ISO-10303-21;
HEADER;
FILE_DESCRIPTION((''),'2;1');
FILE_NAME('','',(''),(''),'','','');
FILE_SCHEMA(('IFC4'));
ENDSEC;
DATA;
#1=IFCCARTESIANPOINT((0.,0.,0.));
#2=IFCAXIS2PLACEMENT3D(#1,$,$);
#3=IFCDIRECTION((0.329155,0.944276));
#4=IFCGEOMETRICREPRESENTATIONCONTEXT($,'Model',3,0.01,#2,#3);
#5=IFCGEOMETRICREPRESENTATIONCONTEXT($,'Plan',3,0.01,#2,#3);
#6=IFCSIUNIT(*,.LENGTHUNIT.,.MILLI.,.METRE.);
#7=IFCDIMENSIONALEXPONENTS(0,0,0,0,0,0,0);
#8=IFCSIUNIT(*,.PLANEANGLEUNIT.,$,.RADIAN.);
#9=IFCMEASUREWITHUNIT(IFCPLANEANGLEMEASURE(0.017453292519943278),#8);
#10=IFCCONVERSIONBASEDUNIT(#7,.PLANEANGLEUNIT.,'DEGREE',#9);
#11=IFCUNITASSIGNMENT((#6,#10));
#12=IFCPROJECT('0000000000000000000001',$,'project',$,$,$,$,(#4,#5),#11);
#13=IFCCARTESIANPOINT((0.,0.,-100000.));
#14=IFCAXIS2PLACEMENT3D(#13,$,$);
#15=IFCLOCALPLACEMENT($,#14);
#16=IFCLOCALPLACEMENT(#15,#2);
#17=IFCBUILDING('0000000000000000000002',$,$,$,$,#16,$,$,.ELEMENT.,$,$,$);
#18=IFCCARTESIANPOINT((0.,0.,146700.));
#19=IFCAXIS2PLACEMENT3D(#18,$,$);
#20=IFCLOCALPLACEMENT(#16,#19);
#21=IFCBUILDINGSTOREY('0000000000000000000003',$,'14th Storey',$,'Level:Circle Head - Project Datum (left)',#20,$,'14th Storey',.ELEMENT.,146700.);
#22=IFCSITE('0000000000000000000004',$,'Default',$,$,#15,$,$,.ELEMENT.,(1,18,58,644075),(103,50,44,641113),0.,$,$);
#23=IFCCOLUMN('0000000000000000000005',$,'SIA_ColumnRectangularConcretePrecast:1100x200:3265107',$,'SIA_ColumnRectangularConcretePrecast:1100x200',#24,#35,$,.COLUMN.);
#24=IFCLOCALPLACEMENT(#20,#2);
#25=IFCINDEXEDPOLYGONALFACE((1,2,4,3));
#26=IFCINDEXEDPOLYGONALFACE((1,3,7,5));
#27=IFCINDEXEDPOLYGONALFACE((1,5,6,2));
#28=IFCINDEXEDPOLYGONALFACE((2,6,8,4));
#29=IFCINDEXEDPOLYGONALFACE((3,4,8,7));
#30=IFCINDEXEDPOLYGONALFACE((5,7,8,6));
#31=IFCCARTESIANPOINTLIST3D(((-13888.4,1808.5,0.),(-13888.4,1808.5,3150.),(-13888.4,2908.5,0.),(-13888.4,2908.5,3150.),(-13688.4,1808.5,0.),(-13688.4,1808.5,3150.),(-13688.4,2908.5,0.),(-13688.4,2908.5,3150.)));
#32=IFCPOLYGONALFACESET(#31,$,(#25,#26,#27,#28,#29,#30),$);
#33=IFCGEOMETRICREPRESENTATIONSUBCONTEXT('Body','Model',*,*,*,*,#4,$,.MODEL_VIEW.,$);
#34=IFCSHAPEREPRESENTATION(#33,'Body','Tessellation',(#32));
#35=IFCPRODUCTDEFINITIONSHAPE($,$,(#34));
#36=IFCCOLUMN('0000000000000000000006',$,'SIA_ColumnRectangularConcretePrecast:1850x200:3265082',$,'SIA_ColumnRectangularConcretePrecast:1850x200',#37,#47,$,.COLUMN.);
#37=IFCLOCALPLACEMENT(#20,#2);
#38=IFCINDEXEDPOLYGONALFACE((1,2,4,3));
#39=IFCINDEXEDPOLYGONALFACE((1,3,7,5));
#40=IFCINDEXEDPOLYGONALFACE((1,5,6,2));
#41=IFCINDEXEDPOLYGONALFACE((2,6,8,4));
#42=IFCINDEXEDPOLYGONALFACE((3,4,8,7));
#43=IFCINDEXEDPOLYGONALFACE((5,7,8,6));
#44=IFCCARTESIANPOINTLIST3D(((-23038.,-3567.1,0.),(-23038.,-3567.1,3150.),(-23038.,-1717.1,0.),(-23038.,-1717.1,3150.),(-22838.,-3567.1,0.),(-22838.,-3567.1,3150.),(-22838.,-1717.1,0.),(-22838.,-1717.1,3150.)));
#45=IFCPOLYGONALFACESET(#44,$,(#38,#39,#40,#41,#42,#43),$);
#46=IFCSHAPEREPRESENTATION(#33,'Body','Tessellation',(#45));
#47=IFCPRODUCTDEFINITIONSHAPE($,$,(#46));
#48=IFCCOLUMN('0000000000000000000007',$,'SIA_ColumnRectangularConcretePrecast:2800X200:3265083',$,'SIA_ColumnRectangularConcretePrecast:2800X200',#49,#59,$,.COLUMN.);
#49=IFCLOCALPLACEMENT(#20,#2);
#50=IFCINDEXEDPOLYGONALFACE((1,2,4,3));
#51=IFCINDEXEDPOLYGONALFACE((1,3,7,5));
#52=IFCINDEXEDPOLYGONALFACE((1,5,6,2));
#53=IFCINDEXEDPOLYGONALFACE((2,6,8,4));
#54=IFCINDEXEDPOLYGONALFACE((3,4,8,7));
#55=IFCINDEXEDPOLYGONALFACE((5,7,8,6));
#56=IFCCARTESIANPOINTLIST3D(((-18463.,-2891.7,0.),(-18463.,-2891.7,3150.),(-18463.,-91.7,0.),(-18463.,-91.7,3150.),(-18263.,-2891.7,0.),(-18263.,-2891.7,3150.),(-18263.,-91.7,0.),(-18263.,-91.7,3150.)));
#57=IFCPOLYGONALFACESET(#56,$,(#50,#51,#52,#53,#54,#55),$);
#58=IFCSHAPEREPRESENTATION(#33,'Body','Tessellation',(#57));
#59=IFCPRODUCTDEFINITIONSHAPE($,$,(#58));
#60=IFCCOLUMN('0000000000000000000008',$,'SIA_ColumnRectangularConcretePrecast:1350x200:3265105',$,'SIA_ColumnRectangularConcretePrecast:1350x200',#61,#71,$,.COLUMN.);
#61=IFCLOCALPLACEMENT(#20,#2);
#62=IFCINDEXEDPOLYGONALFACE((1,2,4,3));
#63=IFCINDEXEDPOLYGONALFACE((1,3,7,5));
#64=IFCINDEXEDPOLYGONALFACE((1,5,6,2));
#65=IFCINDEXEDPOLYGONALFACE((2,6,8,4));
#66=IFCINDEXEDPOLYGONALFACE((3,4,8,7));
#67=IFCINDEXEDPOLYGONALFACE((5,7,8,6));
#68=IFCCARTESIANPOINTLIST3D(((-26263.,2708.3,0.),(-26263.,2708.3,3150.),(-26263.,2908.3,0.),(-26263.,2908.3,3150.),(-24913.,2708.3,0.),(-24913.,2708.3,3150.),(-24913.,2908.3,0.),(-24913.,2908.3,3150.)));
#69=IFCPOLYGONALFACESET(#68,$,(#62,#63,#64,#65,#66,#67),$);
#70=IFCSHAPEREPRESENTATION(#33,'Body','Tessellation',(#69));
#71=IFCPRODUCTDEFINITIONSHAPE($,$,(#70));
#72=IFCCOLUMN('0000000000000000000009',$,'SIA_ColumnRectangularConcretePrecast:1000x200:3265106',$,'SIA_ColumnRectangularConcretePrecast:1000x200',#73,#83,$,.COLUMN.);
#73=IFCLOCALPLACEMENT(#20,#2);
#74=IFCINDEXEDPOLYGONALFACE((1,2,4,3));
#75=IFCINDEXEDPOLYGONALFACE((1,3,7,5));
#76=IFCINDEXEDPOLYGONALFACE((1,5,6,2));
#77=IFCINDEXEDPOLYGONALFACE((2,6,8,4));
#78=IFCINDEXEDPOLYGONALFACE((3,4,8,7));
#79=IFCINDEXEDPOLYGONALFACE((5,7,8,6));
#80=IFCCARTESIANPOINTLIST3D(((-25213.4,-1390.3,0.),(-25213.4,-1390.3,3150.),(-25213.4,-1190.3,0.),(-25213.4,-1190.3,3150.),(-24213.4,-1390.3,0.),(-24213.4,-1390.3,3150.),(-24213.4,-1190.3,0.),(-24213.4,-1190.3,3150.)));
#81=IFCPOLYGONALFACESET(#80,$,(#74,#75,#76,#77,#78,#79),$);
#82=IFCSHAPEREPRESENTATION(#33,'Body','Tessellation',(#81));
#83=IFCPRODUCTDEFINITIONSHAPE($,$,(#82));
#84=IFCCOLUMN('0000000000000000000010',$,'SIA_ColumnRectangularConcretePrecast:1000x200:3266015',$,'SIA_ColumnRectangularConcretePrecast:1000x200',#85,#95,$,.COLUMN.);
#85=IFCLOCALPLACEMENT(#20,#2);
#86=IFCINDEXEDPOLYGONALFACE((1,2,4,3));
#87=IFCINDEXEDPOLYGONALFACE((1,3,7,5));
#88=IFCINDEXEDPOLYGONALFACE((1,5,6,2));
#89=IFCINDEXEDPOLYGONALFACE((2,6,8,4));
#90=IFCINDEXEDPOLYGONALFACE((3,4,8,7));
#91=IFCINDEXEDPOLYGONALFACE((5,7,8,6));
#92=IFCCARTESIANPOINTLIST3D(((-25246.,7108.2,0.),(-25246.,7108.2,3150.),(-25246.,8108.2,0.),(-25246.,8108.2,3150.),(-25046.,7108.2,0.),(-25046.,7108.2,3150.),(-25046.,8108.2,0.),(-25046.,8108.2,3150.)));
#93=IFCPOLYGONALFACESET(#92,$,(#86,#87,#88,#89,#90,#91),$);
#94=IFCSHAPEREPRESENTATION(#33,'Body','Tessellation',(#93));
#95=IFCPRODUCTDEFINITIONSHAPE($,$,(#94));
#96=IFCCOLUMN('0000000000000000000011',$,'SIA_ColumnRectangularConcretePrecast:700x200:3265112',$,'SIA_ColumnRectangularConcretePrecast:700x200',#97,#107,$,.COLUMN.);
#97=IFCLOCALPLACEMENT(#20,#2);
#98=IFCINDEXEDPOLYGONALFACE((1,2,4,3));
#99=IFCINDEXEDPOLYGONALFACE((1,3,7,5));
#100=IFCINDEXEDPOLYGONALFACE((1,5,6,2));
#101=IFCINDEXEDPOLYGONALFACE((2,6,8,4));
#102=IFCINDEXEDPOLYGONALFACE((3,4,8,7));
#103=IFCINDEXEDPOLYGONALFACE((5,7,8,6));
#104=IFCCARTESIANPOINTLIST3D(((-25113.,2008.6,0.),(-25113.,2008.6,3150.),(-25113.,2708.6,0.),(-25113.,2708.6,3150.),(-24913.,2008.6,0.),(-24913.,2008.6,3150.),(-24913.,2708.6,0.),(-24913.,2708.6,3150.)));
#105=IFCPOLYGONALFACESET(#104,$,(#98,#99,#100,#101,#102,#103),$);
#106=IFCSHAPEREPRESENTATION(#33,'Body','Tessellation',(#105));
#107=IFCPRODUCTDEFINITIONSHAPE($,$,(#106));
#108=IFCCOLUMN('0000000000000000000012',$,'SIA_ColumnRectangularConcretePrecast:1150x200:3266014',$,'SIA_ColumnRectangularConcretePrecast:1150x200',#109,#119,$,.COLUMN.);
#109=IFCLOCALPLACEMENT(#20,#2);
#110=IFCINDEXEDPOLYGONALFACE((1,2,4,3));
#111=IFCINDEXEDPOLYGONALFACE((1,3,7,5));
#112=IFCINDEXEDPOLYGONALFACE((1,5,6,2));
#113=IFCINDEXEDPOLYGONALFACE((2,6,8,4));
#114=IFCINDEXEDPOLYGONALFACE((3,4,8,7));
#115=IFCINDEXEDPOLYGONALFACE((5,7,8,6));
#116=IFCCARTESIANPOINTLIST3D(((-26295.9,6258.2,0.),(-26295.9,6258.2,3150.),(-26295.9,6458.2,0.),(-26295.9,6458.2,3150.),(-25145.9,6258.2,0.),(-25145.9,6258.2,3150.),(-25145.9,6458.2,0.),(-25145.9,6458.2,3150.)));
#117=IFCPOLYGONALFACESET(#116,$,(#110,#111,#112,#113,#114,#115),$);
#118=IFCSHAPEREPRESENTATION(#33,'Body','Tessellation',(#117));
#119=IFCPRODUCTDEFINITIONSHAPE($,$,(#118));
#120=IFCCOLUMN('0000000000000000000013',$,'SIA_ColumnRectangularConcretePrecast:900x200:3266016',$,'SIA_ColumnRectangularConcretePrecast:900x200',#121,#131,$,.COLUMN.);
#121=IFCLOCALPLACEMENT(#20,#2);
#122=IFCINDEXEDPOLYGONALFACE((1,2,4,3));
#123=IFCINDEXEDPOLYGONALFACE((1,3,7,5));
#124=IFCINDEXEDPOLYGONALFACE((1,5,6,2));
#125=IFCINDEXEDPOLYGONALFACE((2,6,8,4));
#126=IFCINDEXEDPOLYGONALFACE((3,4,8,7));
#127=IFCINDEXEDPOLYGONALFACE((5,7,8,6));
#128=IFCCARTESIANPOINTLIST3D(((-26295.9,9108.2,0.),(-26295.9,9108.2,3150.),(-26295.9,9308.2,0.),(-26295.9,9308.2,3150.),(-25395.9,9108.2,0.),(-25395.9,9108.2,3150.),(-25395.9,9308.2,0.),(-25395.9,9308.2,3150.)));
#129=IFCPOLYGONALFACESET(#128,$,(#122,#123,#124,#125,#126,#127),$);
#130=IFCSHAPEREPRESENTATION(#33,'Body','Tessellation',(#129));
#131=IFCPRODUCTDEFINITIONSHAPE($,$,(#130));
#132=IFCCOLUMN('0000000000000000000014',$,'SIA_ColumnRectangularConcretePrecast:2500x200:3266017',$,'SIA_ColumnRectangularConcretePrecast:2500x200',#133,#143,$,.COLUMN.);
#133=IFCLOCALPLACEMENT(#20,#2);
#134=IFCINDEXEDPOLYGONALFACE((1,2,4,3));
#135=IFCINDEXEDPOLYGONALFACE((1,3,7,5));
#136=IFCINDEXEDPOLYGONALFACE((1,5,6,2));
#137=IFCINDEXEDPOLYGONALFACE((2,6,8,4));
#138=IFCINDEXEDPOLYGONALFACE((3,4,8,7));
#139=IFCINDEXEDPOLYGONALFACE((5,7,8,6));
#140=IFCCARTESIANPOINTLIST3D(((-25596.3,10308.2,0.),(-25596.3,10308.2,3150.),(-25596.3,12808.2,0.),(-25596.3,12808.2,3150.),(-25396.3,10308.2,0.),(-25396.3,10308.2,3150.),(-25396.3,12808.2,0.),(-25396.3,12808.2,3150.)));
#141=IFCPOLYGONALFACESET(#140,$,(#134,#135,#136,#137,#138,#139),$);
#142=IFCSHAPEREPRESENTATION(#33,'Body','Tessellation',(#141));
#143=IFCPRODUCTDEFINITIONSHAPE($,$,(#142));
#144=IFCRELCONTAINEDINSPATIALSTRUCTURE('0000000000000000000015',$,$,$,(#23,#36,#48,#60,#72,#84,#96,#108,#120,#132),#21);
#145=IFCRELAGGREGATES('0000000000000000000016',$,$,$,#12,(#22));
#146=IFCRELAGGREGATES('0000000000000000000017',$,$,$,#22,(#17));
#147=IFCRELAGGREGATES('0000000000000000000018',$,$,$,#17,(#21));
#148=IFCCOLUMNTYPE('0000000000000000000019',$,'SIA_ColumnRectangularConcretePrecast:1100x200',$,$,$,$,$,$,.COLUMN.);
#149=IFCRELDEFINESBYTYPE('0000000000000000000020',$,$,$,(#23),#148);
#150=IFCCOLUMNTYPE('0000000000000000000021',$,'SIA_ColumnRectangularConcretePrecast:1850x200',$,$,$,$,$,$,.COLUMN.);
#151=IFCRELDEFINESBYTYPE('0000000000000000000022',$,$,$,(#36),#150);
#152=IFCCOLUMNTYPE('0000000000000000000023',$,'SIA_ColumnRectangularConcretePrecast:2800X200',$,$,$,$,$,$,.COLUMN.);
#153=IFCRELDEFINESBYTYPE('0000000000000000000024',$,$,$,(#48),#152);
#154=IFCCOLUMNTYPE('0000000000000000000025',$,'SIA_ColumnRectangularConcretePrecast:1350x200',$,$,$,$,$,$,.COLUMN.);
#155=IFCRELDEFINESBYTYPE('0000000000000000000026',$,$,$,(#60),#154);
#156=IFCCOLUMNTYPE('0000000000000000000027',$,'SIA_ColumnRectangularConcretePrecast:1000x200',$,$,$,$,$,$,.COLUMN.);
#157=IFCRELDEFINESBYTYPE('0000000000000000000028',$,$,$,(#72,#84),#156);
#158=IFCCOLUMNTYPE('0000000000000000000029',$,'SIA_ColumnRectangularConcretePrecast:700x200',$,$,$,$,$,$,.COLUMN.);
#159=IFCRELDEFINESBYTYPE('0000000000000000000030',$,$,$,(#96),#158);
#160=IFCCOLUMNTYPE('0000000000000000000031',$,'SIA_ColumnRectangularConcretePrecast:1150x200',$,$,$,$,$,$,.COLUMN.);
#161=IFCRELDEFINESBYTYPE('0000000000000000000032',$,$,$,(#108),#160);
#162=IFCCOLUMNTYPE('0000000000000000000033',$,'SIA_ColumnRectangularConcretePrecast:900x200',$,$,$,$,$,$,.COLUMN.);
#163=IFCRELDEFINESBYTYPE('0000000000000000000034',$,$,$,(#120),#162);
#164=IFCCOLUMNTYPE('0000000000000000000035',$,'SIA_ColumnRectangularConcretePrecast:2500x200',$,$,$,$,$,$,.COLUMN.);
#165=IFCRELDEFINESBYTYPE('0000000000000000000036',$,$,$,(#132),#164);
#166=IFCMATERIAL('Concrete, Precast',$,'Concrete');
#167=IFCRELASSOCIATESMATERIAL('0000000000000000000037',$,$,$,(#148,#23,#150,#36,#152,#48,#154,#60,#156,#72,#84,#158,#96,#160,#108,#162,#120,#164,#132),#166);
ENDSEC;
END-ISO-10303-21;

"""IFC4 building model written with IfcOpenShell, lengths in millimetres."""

from ifc_helpers import new_model, entity, si_unit, converted_unit, direction, frame, origin, place, context, subcontext, project, spatial, indexed_curve, outline, extrude, source, transform, mapped, material, type_object, type_shapes, element, save


model = new_model("IFC4")

# Units and contexts
model_context = context("Model", 3, precision=0.01, world=origin(), true_north=direction((0.329155, 0.944276)))
plan_context = context("Plan", 3, precision=0.01, world=origin(), true_north=direction((0.329155, 0.944276)))
body_context = subcontext(model_context, "Body", "Model", "MODEL_VIEW")
ifc_project = project(units=[si_unit("LENGTHUNIT", "METRE", prefix="MILLI"), converted_unit("PLANEANGLEUNIT", "DEGREE", entity("IfcPlaneAngleMeasure", 0.017453292519943278), si_unit("PLANEANGLEUNIT", "RADIAN"), dimensions=[0, 0, 0, 0, 0, 0, 0])], contexts=[model_context, plan_context])

# Site, building, storey
site_placement = place(None, frame((0.0, 0.0, -100000.0)))
site = spatial("IfcSite", under=ifc_project, at=site_placement, Name="Default", CompositionType="ELEMENT", RefLatitude=(1, 18, 58, 644075), RefLongitude=(103, 50, 44, 641113), RefElevation=0.0)
building_placement = place(site_placement, origin())
building = spatial("IfcBuilding", under=site, at=building_placement, CompositionType="ELEMENT")
storey_placement = place(building_placement, frame((0.0, 0.0, 146700.0)))
storey = spatial("IfcBuildingStorey", under=building, at=storey_placement, Name="14th Storey", ObjectType="Level:Circle Head - Project Datum (left)", LongName="14th Storey", CompositionType="ELEMENT", Elevation=146700.0)

# Columns
ifc_material_1 = material(Name="Concrete, Precast", Category="Concrete")
column_type_1 = type_object("IfcColumnType", Name="SIA_ColumnRectangularConcretePrecast:1100x200", PredefinedType="COLUMN", material=ifc_material_1)
shared_shape_1 = source(origin(), body_context, "Body", "SweptSolid", [
    extrude(outline(indexed_curve([(-100.0, -550.0), (100.0, -550.0), (100.0, 550.0), (-100.0, 550.0), (-100.0, -550.0)], self_intersect=False)), frame((0.0, 0.0, 146700.0), z_axis=(0.0, 0.0, 1.0), x_axis=(-1.0, 0.0, 0.0)), (0.0, 0.0, 1.0), 3150.0),
])
type_shapes(column_type_1, [shared_shape_1])
for number, where, name in (
    (1, (-13788.4, 2358.5, -146700.0), "SIA_ColumnRectangularConcretePrecast:1100x200:3265107"),
):
    element("IfcColumn", number, at=place(storey_placement, frame(where)), inside=storey, type_object=column_type_1, material=ifc_material_1, Name=name, ObjectType="SIA_ColumnRectangularConcretePrecast:1100x200", PredefinedType="COLUMN", context=body_context, shape_type="MappedRepresentation", body=[
        mapped(shared_shape_1, transform((0.0, 0.0, 0.0), scale=1.0)),
    ])
column_type_2 = type_object("IfcColumnType", Name="SIA_ColumnRectangularConcretePrecast:1850x200", PredefinedType="COLUMN", material=ifc_material_1)
shared_shape_2 = source(origin(), body_context, "Body", "SweptSolid", [
    extrude(outline(indexed_curve([(-100.0, -925.0), (100.0, -925.0), (100.0, 925.0), (-100.0, 925.0), (-100.0, -925.0)], self_intersect=False)), frame((0.0, 0.0, 146700.0), z_axis=(0.0, 0.0, 1.0), x_axis=(-1.0, 0.0, 0.0)), (0.0, 0.0, 1.0), 3150.0),
])
type_shapes(column_type_2, [shared_shape_2])
column_1_placement = place(storey_placement, frame((-22938.0, -2642.1, -146700.0)))
element("IfcColumn", 2, at=column_1_placement, inside=storey, type_object=column_type_2, material=ifc_material_1, Name="SIA_ColumnRectangularConcretePrecast:1850x200:3265082", ObjectType="SIA_ColumnRectangularConcretePrecast:1850x200", PredefinedType="COLUMN", context=body_context, shape_type="MappedRepresentation", body=[
    mapped(shared_shape_2, transform((0.0, 0.0, 0.0), scale=1.0)),
])
column_type_3 = type_object("IfcColumnType", Name="SIA_ColumnRectangularConcretePrecast:2800X200", PredefinedType="COLUMN", material=ifc_material_1)
shared_shape_3 = source(origin(), body_context, "Body", "SweptSolid", [
    extrude(outline(indexed_curve([(-100.0, -1400.0), (100.0, -1400.0), (100.0, 1400.0), (-100.0, 1400.0), (-100.0, -1400.0)], self_intersect=False)), frame((0.0, 0.0, 146700.0), z_axis=(0.0, 0.0, 1.0), x_axis=(-1.0, 0.0, 0.0)), (0.0, 0.0, 1.0), 3150.0),
])
type_shapes(column_type_3, [shared_shape_3])
column_2_placement = place(storey_placement, frame((-18363.0, -1491.7, -146700.0)))
element("IfcColumn", 3, at=column_2_placement, inside=storey, type_object=column_type_3, material=ifc_material_1, Name="SIA_ColumnRectangularConcretePrecast:2800X200:3265083", ObjectType="SIA_ColumnRectangularConcretePrecast:2800X200", PredefinedType="COLUMN", context=body_context, shape_type="MappedRepresentation", body=[
    mapped(shared_shape_3, transform((0.0, 0.0, 0.0), scale=1.0)),
])
column_type_4 = type_object("IfcColumnType", Name="SIA_ColumnRectangularConcretePrecast:1350x200", PredefinedType="COLUMN", material=ifc_material_1)
shared_shape_4 = source(origin(), body_context, "Body", "SweptSolid", [
    extrude(outline(indexed_curve([(-100.0, -675.0), (100.0, -675.0), (100.0, 675.0), (-100.0, 675.0), (-100.0, -675.0)], self_intersect=False)), frame((0.0, 0.0, 146700.0), z_axis=(0.0, 0.0, 1.0), x_axis=(-1.0, 0.0, 0.0)), (0.0, 0.0, 1.0), 3150.0),
])
type_shapes(column_type_4, [shared_shape_4])
column_3_placement = place(storey_placement, frame((-25588.0, 2808.3, -146700.0), z_axis=(0.0, 0.0, 1.0), x_axis=(0.0, -1.0, 0.0)))
element("IfcColumn", 4, at=column_3_placement, inside=storey, type_object=column_type_4, material=ifc_material_1, Name="SIA_ColumnRectangularConcretePrecast:1350x200:3265105", ObjectType="SIA_ColumnRectangularConcretePrecast:1350x200", PredefinedType="COLUMN", context=body_context, shape_type="MappedRepresentation", body=[
    mapped(shared_shape_4, transform((0.0, 0.0, 0.0), scale=1.0)),
])
column_type_5 = type_object("IfcColumnType", Name="SIA_ColumnRectangularConcretePrecast:1000x200", PredefinedType="COLUMN", material=ifc_material_1)
shared_shape_5 = source(origin(), body_context, "Body", "SweptSolid", [
    extrude(outline(indexed_curve([(-100.0, -500.0), (100.0, -500.0), (100.0, 500.0), (-100.0, 500.0), (-100.0, -500.0)], self_intersect=False)), frame((0.0, 0.0, 146700.0), z_axis=(0.0, 0.0, 1.0), x_axis=(-1.0, 0.0, 0.0)), (0.0, 0.0, 1.0), 3150.0),
])
type_shapes(column_type_5, [shared_shape_5])
column_4_placement = place(storey_placement, frame((-24713.4, -1290.3, -146700.0), z_axis=(0.0, 0.0, 1.0), x_axis=(0.0, -1.0, 0.0)))
element("IfcColumn", 5, at=column_4_placement, inside=storey, type_object=column_type_5, material=ifc_material_1, Name="SIA_ColumnRectangularConcretePrecast:1000x200:3265106", ObjectType="SIA_ColumnRectangularConcretePrecast:1000x200", PredefinedType="COLUMN", context=body_context, shape_type="MappedRepresentation", body=[
    mapped(shared_shape_5, transform((0.0, 0.0, 0.0), scale=1.0)),
])
column_5_placement = place(storey_placement, frame((-25146.0, 7608.2, -146700.0)))
element("IfcColumn", 6, at=column_5_placement, inside=storey, type_object=column_type_5, material=ifc_material_1, Name="SIA_ColumnRectangularConcretePrecast:1000x200:3266015", ObjectType="SIA_ColumnRectangularConcretePrecast:1000x200", PredefinedType="COLUMN", context=body_context, shape_type="MappedRepresentation", body=[
    mapped(shared_shape_5, transform((0.0, 0.0, 0.0), scale=1.0)),
])
column_type_6 = type_object("IfcColumnType", Name="SIA_ColumnRectangularConcretePrecast:700x200", PredefinedType="COLUMN", material=ifc_material_1)
shared_shape_6 = source(origin(), body_context, "Body", "SweptSolid", [
    extrude(outline(indexed_curve([(-100.0, -350.0), (100.0, -350.0), (100.0, 350.0), (-100.0, 350.0), (-100.0, -350.0)], self_intersect=False)), frame((0.0, 0.0, 146700.0), z_axis=(0.0, 0.0, 1.0), x_axis=(-1.0, 0.0, 0.0)), (0.0, 0.0, 1.0), 3150.0),
])
type_shapes(column_type_6, [shared_shape_6])
column_6_placement = place(storey_placement, frame((-25013.0, 2358.6, -146700.0)))
element("IfcColumn", 7, at=column_6_placement, inside=storey, type_object=column_type_6, material=ifc_material_1, Name="SIA_ColumnRectangularConcretePrecast:700x200:3265112", ObjectType="SIA_ColumnRectangularConcretePrecast:700x200", PredefinedType="COLUMN", context=body_context, shape_type="MappedRepresentation", body=[
    mapped(shared_shape_6, transform((0.0, 0.0, 0.0), scale=1.0)),
])
column_type_7 = type_object("IfcColumnType", Name="SIA_ColumnRectangularConcretePrecast:1150x200", PredefinedType="COLUMN", material=ifc_material_1)
shared_shape_7 = source(origin(), body_context, "Body", "SweptSolid", [
    extrude(outline(indexed_curve([(-100.0, -575.0), (100.0, -575.0), (100.0, 575.0), (-100.0, 575.0), (-100.0, -575.0)], self_intersect=False)), frame((0.0, 0.0, 146700.0), z_axis=(0.0, 0.0, 1.0), x_axis=(-1.0, 0.0, 0.0)), (0.0, 0.0, 1.0), 3150.0),
])
type_shapes(column_type_7, [shared_shape_7])
column_7_placement = place(storey_placement, frame((-25720.9, 6358.2, -146700.0), z_axis=(0.0, 0.0, 1.0), x_axis=(0.0, 1.0, 0.0)))
element("IfcColumn", 8, at=column_7_placement, inside=storey, type_object=column_type_7, material=ifc_material_1, Name="SIA_ColumnRectangularConcretePrecast:1150x200:3266014", ObjectType="SIA_ColumnRectangularConcretePrecast:1150x200", PredefinedType="COLUMN", context=body_context, shape_type="MappedRepresentation", body=[
    mapped(shared_shape_7, transform((0.0, 0.0, 0.0), scale=1.0)),
])
column_type_8 = type_object("IfcColumnType", Name="SIA_ColumnRectangularConcretePrecast:900x200", PredefinedType="COLUMN", material=ifc_material_1)
shared_shape_8 = source(origin(), body_context, "Body", "SweptSolid", [
    extrude(outline(indexed_curve([(-100.0, -450.0), (100.0, -450.0), (100.0, 450.0), (-100.0, 450.0), (-100.0, -450.0)], self_intersect=False)), frame((0.0, 0.0, 146700.0), z_axis=(0.0, 0.0, 1.0), x_axis=(-1.0, 0.0, 0.0)), (0.0, 0.0, 1.0), 3150.0),
])
type_shapes(column_type_8, [shared_shape_8])
column_8_placement = place(storey_placement, frame((-25845.9, 9208.2, -146700.0), z_axis=(0.0, 0.0, 1.0), x_axis=(0.0, 1.0, 0.0)))
element("IfcColumn", 9, at=column_8_placement, inside=storey, type_object=column_type_8, material=ifc_material_1, Name="SIA_ColumnRectangularConcretePrecast:900x200:3266016", ObjectType="SIA_ColumnRectangularConcretePrecast:900x200", PredefinedType="COLUMN", context=body_context, shape_type="MappedRepresentation", body=[
    mapped(shared_shape_8, transform((0.0, 0.0, 0.0), scale=1.0)),
])
column_type_9 = type_object("IfcColumnType", Name="SIA_ColumnRectangularConcretePrecast:2500x200", PredefinedType="COLUMN", material=ifc_material_1)
shared_shape_9 = source(origin(), body_context, "Body", "SweptSolid", [
    extrude(outline(indexed_curve([(-100.0, -1250.0), (100.0, -1250.0), (100.0, 1250.0), (-100.0, 1250.0), (-100.0, -1250.0)], self_intersect=False)), frame((0.0, 0.0, 146700.0), z_axis=(0.0, 0.0, 1.0), x_axis=(-1.0, 0.0, 0.0)), (0.0, 0.0, 1.0), 3150.0),
])
type_shapes(column_type_9, [shared_shape_9])
column_9_placement = place(storey_placement, frame((-25496.3, 11558.2, -146700.0)))
element("IfcColumn", 10, at=column_9_placement, inside=storey, type_object=column_type_9, material=ifc_material_1, Name="SIA_ColumnRectangularConcretePrecast:2500x200:3266017", ObjectType="SIA_ColumnRectangularConcretePrecast:2500x200", PredefinedType="COLUMN", context=body_context, shape_type="MappedRepresentation", body=[
    mapped(shared_shape_9, transform((0.0, 0.0, 0.0), scale=1.0)),
])

save(model, "model.ifc")
